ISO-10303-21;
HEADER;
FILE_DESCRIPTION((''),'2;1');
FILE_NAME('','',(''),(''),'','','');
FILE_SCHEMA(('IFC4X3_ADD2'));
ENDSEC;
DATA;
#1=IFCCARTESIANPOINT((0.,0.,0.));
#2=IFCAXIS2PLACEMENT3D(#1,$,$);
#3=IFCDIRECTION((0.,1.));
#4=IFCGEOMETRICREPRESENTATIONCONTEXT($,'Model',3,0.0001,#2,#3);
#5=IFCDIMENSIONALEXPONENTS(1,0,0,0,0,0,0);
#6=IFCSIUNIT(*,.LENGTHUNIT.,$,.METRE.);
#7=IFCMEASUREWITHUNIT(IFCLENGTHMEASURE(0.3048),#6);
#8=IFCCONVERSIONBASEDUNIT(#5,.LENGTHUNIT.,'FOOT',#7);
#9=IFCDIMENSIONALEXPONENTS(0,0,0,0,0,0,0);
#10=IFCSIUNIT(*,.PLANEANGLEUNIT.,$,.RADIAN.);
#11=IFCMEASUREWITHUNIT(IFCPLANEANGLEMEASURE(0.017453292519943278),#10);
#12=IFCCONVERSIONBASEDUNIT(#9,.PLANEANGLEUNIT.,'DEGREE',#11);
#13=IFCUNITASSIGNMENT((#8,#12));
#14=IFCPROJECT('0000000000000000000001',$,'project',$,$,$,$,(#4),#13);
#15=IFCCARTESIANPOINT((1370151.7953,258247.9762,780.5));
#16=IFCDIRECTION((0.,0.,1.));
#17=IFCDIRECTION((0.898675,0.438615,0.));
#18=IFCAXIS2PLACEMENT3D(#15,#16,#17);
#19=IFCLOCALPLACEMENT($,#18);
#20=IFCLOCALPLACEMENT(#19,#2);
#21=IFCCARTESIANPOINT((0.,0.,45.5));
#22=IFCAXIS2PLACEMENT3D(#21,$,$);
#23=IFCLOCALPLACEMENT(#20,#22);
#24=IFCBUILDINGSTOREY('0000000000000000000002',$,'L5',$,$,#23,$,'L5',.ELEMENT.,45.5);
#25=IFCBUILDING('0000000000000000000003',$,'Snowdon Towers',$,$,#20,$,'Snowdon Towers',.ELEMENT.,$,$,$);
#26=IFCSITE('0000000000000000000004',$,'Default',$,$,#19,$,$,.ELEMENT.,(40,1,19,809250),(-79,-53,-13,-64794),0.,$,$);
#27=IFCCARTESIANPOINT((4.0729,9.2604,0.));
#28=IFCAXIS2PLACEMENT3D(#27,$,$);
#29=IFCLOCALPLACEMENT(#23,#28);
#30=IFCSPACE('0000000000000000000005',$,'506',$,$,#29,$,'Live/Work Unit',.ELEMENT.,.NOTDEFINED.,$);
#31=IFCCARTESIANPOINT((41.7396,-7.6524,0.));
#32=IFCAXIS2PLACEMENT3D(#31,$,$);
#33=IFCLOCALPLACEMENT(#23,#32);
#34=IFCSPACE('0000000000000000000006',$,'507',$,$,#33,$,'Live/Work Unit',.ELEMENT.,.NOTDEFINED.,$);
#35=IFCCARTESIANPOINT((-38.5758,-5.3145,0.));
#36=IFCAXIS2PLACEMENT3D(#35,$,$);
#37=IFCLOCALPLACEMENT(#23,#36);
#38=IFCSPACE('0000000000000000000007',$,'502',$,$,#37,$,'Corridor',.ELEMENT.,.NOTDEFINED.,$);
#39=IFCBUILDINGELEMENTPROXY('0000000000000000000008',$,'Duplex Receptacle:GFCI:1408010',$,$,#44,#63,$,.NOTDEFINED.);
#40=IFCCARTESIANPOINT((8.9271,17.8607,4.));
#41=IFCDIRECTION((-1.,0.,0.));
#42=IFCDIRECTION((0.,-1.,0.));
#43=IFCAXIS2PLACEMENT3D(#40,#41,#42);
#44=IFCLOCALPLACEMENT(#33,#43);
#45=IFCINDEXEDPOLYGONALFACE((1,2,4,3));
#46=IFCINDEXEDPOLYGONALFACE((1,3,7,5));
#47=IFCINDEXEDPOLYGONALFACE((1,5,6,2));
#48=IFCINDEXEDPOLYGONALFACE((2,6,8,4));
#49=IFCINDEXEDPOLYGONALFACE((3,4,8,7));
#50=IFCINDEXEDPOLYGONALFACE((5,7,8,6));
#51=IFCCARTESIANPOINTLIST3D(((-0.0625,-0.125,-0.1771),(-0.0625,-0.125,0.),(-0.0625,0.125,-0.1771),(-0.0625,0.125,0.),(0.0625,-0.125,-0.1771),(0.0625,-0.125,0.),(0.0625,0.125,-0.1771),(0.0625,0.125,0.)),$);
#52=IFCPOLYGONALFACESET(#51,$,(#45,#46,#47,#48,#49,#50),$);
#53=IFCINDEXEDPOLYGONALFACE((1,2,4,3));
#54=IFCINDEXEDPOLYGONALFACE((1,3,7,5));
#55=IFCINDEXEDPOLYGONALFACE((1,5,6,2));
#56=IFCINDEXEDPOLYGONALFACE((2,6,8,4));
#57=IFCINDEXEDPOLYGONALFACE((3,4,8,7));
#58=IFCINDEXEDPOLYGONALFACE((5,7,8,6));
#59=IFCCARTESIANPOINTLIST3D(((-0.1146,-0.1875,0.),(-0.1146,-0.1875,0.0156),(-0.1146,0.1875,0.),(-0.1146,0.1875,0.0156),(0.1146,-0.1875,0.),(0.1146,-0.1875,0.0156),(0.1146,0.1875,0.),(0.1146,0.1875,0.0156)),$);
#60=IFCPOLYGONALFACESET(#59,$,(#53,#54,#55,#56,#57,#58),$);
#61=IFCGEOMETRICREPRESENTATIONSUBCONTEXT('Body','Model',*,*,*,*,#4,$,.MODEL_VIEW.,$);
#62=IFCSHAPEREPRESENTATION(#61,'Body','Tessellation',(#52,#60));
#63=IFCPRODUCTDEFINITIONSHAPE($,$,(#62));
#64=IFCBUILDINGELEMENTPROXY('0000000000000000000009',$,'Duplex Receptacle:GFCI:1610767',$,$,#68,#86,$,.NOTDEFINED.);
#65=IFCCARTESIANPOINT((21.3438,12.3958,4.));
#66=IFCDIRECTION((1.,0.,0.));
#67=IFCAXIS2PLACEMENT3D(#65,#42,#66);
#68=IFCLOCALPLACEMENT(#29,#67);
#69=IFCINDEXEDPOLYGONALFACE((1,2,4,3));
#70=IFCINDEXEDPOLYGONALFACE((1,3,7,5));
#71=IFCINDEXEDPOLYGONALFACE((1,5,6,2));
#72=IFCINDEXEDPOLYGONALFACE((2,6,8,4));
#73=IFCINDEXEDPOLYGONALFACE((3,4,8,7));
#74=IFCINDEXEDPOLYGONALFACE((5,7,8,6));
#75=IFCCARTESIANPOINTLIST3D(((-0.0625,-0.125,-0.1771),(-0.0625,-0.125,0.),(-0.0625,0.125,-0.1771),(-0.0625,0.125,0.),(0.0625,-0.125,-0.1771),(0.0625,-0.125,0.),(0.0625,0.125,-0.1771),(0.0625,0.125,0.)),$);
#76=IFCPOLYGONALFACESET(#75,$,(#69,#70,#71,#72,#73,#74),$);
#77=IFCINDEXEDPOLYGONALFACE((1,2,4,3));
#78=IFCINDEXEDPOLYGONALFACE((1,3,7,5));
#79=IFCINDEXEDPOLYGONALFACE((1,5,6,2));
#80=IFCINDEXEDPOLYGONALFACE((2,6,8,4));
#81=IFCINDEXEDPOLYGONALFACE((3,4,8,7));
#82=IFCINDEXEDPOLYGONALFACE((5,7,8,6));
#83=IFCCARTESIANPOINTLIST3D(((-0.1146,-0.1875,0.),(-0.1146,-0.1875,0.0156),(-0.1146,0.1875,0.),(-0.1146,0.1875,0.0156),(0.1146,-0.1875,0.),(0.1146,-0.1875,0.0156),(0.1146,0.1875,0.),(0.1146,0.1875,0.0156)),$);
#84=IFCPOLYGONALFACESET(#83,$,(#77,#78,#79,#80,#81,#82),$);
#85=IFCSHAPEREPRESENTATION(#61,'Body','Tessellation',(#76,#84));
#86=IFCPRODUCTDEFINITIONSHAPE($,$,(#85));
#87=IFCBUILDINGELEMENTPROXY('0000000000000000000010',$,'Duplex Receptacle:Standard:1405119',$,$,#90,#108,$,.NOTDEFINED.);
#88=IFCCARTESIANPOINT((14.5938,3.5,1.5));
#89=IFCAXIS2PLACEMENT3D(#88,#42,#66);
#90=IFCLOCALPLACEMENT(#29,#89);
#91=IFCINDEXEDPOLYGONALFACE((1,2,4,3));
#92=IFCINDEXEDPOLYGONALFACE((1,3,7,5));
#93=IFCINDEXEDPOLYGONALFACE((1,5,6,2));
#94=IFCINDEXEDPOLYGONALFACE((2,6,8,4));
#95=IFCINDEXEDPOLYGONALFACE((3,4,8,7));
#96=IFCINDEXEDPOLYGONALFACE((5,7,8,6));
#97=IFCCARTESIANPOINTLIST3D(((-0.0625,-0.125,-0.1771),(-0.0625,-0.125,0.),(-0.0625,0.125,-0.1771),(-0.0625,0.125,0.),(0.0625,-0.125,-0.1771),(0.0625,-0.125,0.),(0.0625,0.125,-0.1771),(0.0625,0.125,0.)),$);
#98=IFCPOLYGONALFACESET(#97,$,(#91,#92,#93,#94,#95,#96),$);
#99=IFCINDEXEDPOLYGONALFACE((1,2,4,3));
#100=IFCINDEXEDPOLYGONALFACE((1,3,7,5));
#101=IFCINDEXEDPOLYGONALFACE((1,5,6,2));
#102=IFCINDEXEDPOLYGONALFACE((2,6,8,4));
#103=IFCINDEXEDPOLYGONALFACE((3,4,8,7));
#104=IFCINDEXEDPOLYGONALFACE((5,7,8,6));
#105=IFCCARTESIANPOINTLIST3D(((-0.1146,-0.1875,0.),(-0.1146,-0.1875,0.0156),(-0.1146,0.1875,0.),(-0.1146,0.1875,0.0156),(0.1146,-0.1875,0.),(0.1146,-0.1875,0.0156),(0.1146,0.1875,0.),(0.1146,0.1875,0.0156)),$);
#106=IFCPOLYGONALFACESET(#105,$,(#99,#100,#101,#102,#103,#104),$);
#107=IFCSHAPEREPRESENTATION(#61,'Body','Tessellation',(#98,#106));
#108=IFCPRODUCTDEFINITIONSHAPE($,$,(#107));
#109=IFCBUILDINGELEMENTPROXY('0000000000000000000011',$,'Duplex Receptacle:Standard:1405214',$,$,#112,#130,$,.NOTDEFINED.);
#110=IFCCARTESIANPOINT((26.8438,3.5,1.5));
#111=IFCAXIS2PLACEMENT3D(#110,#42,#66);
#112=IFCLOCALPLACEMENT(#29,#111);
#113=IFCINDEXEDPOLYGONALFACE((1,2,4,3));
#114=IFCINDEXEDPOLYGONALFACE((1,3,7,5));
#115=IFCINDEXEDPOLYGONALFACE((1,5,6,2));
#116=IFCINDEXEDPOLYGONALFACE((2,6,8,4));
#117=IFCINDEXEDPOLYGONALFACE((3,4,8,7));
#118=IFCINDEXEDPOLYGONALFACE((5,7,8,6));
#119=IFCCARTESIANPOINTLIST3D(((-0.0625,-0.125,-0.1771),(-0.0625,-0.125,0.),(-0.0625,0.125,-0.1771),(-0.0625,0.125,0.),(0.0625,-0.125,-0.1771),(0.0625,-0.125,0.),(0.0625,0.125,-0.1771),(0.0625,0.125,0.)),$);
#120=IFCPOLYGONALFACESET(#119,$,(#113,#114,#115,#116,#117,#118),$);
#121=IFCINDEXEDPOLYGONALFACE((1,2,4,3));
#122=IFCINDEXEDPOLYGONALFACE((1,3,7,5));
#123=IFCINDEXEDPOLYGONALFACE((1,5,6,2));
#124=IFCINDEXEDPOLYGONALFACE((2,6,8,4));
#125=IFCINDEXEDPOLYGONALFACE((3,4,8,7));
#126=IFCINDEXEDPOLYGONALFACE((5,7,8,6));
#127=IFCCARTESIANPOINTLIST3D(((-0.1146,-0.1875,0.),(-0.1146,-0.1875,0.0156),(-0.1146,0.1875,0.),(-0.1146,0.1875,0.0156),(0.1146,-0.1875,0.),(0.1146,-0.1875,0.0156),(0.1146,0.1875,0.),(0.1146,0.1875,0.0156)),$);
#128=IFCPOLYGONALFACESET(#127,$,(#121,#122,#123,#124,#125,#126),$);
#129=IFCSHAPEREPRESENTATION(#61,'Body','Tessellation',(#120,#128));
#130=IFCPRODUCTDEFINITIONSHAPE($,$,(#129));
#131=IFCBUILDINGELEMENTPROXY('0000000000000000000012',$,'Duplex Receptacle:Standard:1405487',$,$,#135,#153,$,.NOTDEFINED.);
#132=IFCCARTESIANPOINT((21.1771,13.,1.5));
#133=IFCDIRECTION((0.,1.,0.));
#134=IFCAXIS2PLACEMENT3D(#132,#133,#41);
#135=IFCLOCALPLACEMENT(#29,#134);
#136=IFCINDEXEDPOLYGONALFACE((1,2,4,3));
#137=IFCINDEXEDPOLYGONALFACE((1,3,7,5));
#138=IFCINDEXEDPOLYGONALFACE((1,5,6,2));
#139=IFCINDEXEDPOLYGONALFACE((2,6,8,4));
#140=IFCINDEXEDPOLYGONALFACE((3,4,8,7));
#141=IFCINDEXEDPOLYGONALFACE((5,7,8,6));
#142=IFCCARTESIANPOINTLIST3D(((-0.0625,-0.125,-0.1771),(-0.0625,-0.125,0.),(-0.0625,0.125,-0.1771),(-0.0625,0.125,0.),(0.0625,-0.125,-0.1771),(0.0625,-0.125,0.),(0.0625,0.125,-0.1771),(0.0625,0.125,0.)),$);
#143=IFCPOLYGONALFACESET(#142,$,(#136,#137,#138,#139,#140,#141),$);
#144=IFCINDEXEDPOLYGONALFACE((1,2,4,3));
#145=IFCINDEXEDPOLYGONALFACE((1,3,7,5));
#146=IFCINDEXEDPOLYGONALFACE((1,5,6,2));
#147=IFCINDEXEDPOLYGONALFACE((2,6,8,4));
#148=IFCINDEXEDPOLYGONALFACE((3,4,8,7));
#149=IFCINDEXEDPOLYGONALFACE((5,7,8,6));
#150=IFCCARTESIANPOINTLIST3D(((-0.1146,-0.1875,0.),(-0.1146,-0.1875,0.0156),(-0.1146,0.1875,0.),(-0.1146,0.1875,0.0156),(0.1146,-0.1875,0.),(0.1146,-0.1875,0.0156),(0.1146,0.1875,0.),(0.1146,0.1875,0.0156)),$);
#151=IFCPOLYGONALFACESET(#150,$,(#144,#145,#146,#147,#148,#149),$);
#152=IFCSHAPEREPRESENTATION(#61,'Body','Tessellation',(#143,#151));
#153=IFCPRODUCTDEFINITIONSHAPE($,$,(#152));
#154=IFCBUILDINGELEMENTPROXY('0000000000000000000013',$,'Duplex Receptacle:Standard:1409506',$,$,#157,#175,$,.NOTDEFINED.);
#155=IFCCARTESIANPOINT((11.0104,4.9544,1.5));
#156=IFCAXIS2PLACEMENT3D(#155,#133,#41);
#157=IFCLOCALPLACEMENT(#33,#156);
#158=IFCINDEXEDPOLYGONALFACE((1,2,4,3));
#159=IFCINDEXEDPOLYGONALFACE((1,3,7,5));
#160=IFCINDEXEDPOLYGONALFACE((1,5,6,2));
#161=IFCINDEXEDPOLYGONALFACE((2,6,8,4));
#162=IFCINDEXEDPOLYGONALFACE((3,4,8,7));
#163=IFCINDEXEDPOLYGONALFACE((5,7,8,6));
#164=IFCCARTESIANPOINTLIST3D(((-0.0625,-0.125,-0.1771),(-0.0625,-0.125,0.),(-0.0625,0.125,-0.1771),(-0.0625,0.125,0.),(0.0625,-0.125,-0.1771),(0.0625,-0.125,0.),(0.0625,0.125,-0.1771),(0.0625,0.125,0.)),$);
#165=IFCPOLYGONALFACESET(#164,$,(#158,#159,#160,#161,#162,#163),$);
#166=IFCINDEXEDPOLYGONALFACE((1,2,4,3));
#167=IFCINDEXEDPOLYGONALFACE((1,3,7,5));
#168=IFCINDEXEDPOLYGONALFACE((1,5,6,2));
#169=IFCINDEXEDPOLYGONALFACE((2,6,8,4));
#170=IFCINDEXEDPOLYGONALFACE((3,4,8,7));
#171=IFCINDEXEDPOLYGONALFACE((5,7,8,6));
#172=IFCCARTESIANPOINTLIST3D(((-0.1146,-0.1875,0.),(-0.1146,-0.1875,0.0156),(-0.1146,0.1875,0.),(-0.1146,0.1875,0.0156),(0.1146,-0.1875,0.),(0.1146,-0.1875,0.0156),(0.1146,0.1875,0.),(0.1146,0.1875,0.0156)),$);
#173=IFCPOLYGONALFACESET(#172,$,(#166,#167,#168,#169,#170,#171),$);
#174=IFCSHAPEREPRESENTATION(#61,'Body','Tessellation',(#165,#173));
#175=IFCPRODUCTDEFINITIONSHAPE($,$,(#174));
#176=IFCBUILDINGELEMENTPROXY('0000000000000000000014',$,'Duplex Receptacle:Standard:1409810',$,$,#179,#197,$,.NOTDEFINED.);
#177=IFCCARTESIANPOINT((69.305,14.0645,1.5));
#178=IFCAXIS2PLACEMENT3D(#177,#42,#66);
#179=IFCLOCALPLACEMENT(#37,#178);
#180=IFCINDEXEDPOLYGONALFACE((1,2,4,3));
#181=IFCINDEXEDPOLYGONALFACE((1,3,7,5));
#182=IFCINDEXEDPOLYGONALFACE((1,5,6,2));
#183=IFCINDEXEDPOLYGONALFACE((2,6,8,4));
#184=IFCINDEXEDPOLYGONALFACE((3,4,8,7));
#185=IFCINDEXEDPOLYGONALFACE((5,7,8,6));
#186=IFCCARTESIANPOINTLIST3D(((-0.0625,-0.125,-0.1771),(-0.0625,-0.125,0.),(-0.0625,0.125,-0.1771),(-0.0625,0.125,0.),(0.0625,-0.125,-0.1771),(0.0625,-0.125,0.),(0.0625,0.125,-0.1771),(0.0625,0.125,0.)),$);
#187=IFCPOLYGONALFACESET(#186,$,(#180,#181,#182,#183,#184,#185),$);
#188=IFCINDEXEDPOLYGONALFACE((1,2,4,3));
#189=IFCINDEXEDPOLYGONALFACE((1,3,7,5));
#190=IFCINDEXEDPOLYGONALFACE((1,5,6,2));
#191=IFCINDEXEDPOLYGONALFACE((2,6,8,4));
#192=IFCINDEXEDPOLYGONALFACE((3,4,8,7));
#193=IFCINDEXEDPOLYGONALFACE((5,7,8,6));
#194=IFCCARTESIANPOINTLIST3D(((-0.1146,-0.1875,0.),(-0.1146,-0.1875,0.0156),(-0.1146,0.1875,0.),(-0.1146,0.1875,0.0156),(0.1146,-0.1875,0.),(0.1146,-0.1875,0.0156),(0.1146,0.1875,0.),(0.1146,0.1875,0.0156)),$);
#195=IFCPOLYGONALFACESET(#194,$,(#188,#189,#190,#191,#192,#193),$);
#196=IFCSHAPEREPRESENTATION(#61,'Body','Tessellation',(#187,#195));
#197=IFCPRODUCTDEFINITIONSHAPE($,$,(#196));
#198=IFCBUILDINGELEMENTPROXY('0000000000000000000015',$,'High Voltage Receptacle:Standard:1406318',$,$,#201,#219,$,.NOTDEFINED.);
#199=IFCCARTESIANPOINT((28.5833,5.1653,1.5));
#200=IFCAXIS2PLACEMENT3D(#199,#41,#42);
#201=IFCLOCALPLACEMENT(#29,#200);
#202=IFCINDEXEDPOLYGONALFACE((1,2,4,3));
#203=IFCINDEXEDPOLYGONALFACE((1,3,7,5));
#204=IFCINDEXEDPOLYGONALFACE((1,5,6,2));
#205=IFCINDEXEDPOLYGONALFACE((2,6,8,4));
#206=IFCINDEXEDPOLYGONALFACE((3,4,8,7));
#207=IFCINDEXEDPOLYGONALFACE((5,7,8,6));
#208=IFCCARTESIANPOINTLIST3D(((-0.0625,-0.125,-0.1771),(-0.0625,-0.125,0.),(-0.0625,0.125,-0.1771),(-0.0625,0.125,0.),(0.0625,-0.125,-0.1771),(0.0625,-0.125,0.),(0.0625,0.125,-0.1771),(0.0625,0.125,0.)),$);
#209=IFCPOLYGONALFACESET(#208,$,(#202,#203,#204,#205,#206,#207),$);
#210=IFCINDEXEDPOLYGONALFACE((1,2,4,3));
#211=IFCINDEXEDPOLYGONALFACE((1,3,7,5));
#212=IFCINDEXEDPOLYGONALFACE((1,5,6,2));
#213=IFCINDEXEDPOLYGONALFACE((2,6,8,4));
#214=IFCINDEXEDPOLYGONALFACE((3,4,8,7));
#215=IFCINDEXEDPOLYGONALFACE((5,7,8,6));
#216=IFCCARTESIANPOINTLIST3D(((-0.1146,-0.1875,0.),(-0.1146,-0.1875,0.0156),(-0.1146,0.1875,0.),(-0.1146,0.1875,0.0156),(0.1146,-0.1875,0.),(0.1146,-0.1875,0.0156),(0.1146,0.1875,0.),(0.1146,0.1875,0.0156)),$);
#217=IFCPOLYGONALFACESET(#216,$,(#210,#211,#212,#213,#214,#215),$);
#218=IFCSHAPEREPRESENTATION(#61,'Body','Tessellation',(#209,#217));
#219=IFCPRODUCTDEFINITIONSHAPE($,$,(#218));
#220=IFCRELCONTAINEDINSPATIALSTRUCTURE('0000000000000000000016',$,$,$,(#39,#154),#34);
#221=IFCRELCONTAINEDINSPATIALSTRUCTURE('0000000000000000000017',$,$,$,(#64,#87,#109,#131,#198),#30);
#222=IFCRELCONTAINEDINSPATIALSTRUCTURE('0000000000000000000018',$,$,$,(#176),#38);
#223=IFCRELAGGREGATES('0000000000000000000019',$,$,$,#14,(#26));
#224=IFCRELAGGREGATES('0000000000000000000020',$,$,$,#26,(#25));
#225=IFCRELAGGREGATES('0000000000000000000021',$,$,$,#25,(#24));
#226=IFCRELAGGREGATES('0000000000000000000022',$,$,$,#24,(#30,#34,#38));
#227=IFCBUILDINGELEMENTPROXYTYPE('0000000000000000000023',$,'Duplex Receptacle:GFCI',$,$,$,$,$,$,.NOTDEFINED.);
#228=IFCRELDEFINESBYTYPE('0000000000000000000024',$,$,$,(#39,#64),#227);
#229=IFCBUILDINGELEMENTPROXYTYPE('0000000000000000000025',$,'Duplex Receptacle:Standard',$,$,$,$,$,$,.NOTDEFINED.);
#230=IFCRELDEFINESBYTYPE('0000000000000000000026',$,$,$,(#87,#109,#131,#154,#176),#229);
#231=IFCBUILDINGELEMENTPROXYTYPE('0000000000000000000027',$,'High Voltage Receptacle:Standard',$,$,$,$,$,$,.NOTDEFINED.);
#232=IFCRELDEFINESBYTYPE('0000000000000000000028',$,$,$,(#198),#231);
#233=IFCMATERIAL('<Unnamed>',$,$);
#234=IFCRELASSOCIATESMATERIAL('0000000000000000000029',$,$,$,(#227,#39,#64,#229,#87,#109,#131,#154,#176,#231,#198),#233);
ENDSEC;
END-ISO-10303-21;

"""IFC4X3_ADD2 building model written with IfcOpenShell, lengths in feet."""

from ifc_helpers import new_model, entity, si_unit, converted_unit, direction, frame, frame_2d, origin, origin_2d_with_axis, place, context, subcontext, project, spatial, rectangle, extrude, source, transform, mapped, material, type_object, type_shapes, element, save


model = new_model("IFC4X3_ADD2")

# Units and contexts
model_context = context("Model", 3, precision=0.0001, world=origin(), true_north=direction((0.0, 1.0)))
body_context = subcontext(model_context, "Body", "Model", "MODEL_VIEW")
ifc_project = project(units=[converted_unit("LENGTHUNIT", "FOOT", entity("IfcLengthMeasure", 0.3048), si_unit("LENGTHUNIT", "METRE"), dimensions=[1, 0, 0, 0, 0, 0, 0]), converted_unit("PLANEANGLEUNIT", "DEGREE", entity("IfcPlaneAngleMeasure", 0.017453292519943278), si_unit("PLANEANGLEUNIT", "RADIAN"), dimensions=[0, 0, 0, 0, 0, 0, 0])], contexts=[model_context])

# Site, building, storey, space
site_placement = place(None, frame((1370151.7953, 258247.9762, 780.5), z_axis=(0.0, 0.0, 1.0), x_axis=(0.898675, 0.438615, 0.0)))
site = spatial("IfcSite", under=ifc_project, at=site_placement, Name="Default", CompositionType="ELEMENT", RefLatitude=(40, 1, 19, 809250), RefLongitude=(-79, -53, -13, -64794), RefElevation=0.0)
building_placement = place(site_placement, origin())
building = spatial("IfcBuilding", under=site, at=building_placement, Name="Snowdon Towers", LongName="Snowdon Towers", CompositionType="ELEMENT")
storey_placement = place(building_placement, frame((0.0, 0.0, 45.5)))
storey = spatial("IfcBuildingStorey", under=building, at=storey_placement, Name="L5", LongName="L5", CompositionType="ELEMENT", Elevation=45.5)
space_1_placement = place(storey_placement, frame((4.0729, 9.2604, 0.0)))
space_1 = spatial("IfcSpace", under=storey, at=space_1_placement, Name="506", LongName="Live/Work Unit", CompositionType="ELEMENT", PredefinedType="NOTDEFINED")

# Shared definitions
ifc_material_1 = material(Name="<Unnamed>")

# Shared definitions
space_2_placement = place(storey_placement, frame((41.7396, -7.6524, 0.0)))
space_2 = spatial("IfcSpace", under=storey, at=space_2_placement, Name="507", LongName="Live/Work Unit", CompositionType="ELEMENT", PredefinedType="NOTDEFINED")

# Building element proxies
building_element_proxy_type_1 = type_object("IfcBuildingElementProxyType", Name="Duplex Receptacle:GFCI", PredefinedType="NOTDEFINED", material=ifc_material_1)
shared_shape_1 = source(origin(), body_context, "Body", "SweptSolid", [
    extrude(rectangle(XDim=0.125, YDim=0.25, at=origin_2d_with_axis()), frame((0.0, 0.0, -0.1771), z_axis=(0.0, 0.0, 1.0), x_axis=(-1.0, 0.0, 0.0)), (0.0, 0.0, 1.0), 0.1771),
    extrude(rectangle(XDim=0.2292, YDim=0.375, at=frame_2d((0.0, 0.0), x_axis=(1.0, 0.0))), frame((0.0, 0.0, 0.0), z_axis=(0.0, 0.0, 1.0), x_axis=(-1.0, 0.0, 0.0)), (0.0, 0.0, 1.0), 0.0156),
])
type_shapes(building_element_proxy_type_1, [shared_shape_1])
proxy_1_placement = place(space_2_placement, frame((8.9271, 17.8607, 4.0), z_axis=(-1.0, 0.0, 0.0), x_axis=(0.0, -1.0, 0.0)))
element("IfcBuildingElementProxy", 1, at=proxy_1_placement, inside=space_2, type_object=building_element_proxy_type_1, material=ifc_material_1, Name="Duplex Receptacle:GFCI:1408010", PredefinedType="NOTDEFINED", context=body_context, shape_type="MappedRepresentation", body=[
    mapped(shared_shape_1, transform((0.0, 0.0, 0.0), scale=1.0)),
])
proxy_2_placement = place(space_1_placement, frame((21.3438, 12.3958, 4.0), z_axis=(0.0, -1.0, 0.0), x_axis=(1.0, 0.0, 0.0)))
element("IfcBuildingElementProxy", 2, at=proxy_2_placement, inside=space_1, type_object=building_element_proxy_type_1, material=ifc_material_1, Name="Duplex Receptacle:GFCI:1610767", PredefinedType="NOTDEFINED", context=body_context, shape_type="MappedRepresentation", body=[
    mapped(shared_shape_1, transform((0.0, 0.0, 0.0), scale=1.0)),
])
building_element_proxy_type_2 = type_object("IfcBuildingElementProxyType", Name="Duplex Receptacle:Standard", PredefinedType="NOTDEFINED", material=ifc_material_1)
shared_shape_2 = source(origin(), body_context, "Body", "SweptSolid", [
    extrude(rectangle(XDim=0.125, YDim=0.25, at=origin_2d_with_axis()), frame((0.0, 0.0, -0.1771), z_axis=(0.0, 0.0, 1.0), x_axis=(-1.0, 0.0, 0.0)), (0.0, 0.0, 1.0), 0.1771),
    extrude(rectangle(XDim=0.2292, YDim=0.375, at=frame_2d((0.0, 0.0), x_axis=(1.0, 0.0))), frame((0.0, 0.0, 0.0), z_axis=(0.0, 0.0, 1.0), x_axis=(-1.0, 0.0, 0.0)), (0.0, 0.0, 1.0), 0.0156),
])
type_shapes(building_element_proxy_type_2, [shared_shape_2])
for number, where, z_axis, x_axis, name in (
    (3, (14.5938, 3.5, 1.5), (0.0, -1.0, 0.0), (1.0, 0.0, 0.0), "Duplex Receptacle:Standard:1405119"),
    (4, (26.8438, 3.5, 1.5), (0.0, -1.0, 0.0), (1.0, 0.0, 0.0), "Duplex Receptacle:Standard:1405214"),
    (5, (21.1771, 13.0, 1.5), (0.0, 1.0, 0.0), (-1.0, 0.0, 0.0), "Duplex Receptacle:Standard:1405487"),
):
    element("IfcBuildingElementProxy", number, at=place(space_1_placement, frame(where, z_axis=z_axis, x_axis=x_axis)), inside=space_1, type_object=building_element_proxy_type_2, material=ifc_material_1, Name=name, PredefinedType="NOTDEFINED", context=body_context, shape_type="MappedRepresentation", body=[
        mapped(shared_shape_2, transform((0.0, 0.0, 0.0), scale=1.0)),
    ])
for number, where, z_axis, x_axis, name in (
    (6, (11.0104, 4.9544, 1.5), (0.0, 1.0, 0.0), (-1.0, 0.0, 0.0), "Duplex Receptacle:Standard:1409506"),
):
    element("IfcBuildingElementProxy", number, at=place(space_2_placement, frame(where, z_axis=z_axis, x_axis=x_axis)), inside=space_2, type_object=building_element_proxy_type_2, material=ifc_material_1, Name=name, PredefinedType="NOTDEFINED", context=body_context, shape_type="MappedRepresentation", body=[
        mapped(shared_shape_2, transform((0.0, 0.0, 0.0), scale=1.0)),
    ])

# Shared definitions
space_3_placement = place(storey_placement, frame((-38.5758, -5.3145, 0.0)))
space_3 = spatial("IfcSpace", under=storey, at=space_3_placement, Name="502", LongName="Corridor", CompositionType="ELEMENT", PredefinedType="NOTDEFINED")

# Building element proxies
proxy_3_placement = place(space_3_placement, frame((69.305, 14.0645, 1.5), z_axis=(0.0, -1.0, 0.0), x_axis=(1.0, 0.0, 0.0)))
element("IfcBuildingElementProxy", 7, at=proxy_3_placement, inside=space_3, type_object=building_element_proxy_type_2, material=ifc_material_1, Name="Duplex Receptacle:Standard:1409810", PredefinedType="NOTDEFINED", context=body_context, shape_type="MappedRepresentation", body=[
    mapped(shared_shape_2, transform((0.0, 0.0, 0.0), scale=1.0)),
])
building_element_proxy_type_3 = type_object("IfcBuildingElementProxyType", Name="High Voltage Receptacle:Standard", PredefinedType="NOTDEFINED", material=ifc_material_1)
shared_shape_3 = source(origin(), body_context, "Body", "SweptSolid", [
    extrude(rectangle(XDim=0.125, YDim=0.25, at=origin_2d_with_axis()), frame((0.0, 0.0, -0.1771), z_axis=(0.0, 0.0, 1.0), x_axis=(-1.0, 0.0, 0.0)), (0.0, 0.0, 1.0), 0.1771),
    extrude(rectangle(XDim=0.2292, YDim=0.375, at=frame_2d((0.0, 0.0), x_axis=(1.0, 0.0))), frame((0.0, 0.0, 0.0), z_axis=(0.0, 0.0, 1.0), x_axis=(-1.0, 0.0, 0.0)), (0.0, 0.0, 1.0), 0.0156),
])
type_shapes(building_element_proxy_type_3, [shared_shape_3])
proxy_4_placement = place(space_1_placement, frame((28.5833, 5.1653, 1.5), z_axis=(-1.0, 0.0, 0.0), x_axis=(0.0, -1.0, 0.0)))
element("IfcBuildingElementProxy", 8, at=proxy_4_placement, inside=space_1, type_object=building_element_proxy_type_3, material=ifc_material_1, Name="High Voltage Receptacle:Standard:1406318", PredefinedType="NOTDEFINED", context=body_context, shape_type="MappedRepresentation", body=[
    mapped(shared_shape_3, transform((0.0, 0.0, 0.0), scale=1.0)),
])

save(model, "model.ifc")
